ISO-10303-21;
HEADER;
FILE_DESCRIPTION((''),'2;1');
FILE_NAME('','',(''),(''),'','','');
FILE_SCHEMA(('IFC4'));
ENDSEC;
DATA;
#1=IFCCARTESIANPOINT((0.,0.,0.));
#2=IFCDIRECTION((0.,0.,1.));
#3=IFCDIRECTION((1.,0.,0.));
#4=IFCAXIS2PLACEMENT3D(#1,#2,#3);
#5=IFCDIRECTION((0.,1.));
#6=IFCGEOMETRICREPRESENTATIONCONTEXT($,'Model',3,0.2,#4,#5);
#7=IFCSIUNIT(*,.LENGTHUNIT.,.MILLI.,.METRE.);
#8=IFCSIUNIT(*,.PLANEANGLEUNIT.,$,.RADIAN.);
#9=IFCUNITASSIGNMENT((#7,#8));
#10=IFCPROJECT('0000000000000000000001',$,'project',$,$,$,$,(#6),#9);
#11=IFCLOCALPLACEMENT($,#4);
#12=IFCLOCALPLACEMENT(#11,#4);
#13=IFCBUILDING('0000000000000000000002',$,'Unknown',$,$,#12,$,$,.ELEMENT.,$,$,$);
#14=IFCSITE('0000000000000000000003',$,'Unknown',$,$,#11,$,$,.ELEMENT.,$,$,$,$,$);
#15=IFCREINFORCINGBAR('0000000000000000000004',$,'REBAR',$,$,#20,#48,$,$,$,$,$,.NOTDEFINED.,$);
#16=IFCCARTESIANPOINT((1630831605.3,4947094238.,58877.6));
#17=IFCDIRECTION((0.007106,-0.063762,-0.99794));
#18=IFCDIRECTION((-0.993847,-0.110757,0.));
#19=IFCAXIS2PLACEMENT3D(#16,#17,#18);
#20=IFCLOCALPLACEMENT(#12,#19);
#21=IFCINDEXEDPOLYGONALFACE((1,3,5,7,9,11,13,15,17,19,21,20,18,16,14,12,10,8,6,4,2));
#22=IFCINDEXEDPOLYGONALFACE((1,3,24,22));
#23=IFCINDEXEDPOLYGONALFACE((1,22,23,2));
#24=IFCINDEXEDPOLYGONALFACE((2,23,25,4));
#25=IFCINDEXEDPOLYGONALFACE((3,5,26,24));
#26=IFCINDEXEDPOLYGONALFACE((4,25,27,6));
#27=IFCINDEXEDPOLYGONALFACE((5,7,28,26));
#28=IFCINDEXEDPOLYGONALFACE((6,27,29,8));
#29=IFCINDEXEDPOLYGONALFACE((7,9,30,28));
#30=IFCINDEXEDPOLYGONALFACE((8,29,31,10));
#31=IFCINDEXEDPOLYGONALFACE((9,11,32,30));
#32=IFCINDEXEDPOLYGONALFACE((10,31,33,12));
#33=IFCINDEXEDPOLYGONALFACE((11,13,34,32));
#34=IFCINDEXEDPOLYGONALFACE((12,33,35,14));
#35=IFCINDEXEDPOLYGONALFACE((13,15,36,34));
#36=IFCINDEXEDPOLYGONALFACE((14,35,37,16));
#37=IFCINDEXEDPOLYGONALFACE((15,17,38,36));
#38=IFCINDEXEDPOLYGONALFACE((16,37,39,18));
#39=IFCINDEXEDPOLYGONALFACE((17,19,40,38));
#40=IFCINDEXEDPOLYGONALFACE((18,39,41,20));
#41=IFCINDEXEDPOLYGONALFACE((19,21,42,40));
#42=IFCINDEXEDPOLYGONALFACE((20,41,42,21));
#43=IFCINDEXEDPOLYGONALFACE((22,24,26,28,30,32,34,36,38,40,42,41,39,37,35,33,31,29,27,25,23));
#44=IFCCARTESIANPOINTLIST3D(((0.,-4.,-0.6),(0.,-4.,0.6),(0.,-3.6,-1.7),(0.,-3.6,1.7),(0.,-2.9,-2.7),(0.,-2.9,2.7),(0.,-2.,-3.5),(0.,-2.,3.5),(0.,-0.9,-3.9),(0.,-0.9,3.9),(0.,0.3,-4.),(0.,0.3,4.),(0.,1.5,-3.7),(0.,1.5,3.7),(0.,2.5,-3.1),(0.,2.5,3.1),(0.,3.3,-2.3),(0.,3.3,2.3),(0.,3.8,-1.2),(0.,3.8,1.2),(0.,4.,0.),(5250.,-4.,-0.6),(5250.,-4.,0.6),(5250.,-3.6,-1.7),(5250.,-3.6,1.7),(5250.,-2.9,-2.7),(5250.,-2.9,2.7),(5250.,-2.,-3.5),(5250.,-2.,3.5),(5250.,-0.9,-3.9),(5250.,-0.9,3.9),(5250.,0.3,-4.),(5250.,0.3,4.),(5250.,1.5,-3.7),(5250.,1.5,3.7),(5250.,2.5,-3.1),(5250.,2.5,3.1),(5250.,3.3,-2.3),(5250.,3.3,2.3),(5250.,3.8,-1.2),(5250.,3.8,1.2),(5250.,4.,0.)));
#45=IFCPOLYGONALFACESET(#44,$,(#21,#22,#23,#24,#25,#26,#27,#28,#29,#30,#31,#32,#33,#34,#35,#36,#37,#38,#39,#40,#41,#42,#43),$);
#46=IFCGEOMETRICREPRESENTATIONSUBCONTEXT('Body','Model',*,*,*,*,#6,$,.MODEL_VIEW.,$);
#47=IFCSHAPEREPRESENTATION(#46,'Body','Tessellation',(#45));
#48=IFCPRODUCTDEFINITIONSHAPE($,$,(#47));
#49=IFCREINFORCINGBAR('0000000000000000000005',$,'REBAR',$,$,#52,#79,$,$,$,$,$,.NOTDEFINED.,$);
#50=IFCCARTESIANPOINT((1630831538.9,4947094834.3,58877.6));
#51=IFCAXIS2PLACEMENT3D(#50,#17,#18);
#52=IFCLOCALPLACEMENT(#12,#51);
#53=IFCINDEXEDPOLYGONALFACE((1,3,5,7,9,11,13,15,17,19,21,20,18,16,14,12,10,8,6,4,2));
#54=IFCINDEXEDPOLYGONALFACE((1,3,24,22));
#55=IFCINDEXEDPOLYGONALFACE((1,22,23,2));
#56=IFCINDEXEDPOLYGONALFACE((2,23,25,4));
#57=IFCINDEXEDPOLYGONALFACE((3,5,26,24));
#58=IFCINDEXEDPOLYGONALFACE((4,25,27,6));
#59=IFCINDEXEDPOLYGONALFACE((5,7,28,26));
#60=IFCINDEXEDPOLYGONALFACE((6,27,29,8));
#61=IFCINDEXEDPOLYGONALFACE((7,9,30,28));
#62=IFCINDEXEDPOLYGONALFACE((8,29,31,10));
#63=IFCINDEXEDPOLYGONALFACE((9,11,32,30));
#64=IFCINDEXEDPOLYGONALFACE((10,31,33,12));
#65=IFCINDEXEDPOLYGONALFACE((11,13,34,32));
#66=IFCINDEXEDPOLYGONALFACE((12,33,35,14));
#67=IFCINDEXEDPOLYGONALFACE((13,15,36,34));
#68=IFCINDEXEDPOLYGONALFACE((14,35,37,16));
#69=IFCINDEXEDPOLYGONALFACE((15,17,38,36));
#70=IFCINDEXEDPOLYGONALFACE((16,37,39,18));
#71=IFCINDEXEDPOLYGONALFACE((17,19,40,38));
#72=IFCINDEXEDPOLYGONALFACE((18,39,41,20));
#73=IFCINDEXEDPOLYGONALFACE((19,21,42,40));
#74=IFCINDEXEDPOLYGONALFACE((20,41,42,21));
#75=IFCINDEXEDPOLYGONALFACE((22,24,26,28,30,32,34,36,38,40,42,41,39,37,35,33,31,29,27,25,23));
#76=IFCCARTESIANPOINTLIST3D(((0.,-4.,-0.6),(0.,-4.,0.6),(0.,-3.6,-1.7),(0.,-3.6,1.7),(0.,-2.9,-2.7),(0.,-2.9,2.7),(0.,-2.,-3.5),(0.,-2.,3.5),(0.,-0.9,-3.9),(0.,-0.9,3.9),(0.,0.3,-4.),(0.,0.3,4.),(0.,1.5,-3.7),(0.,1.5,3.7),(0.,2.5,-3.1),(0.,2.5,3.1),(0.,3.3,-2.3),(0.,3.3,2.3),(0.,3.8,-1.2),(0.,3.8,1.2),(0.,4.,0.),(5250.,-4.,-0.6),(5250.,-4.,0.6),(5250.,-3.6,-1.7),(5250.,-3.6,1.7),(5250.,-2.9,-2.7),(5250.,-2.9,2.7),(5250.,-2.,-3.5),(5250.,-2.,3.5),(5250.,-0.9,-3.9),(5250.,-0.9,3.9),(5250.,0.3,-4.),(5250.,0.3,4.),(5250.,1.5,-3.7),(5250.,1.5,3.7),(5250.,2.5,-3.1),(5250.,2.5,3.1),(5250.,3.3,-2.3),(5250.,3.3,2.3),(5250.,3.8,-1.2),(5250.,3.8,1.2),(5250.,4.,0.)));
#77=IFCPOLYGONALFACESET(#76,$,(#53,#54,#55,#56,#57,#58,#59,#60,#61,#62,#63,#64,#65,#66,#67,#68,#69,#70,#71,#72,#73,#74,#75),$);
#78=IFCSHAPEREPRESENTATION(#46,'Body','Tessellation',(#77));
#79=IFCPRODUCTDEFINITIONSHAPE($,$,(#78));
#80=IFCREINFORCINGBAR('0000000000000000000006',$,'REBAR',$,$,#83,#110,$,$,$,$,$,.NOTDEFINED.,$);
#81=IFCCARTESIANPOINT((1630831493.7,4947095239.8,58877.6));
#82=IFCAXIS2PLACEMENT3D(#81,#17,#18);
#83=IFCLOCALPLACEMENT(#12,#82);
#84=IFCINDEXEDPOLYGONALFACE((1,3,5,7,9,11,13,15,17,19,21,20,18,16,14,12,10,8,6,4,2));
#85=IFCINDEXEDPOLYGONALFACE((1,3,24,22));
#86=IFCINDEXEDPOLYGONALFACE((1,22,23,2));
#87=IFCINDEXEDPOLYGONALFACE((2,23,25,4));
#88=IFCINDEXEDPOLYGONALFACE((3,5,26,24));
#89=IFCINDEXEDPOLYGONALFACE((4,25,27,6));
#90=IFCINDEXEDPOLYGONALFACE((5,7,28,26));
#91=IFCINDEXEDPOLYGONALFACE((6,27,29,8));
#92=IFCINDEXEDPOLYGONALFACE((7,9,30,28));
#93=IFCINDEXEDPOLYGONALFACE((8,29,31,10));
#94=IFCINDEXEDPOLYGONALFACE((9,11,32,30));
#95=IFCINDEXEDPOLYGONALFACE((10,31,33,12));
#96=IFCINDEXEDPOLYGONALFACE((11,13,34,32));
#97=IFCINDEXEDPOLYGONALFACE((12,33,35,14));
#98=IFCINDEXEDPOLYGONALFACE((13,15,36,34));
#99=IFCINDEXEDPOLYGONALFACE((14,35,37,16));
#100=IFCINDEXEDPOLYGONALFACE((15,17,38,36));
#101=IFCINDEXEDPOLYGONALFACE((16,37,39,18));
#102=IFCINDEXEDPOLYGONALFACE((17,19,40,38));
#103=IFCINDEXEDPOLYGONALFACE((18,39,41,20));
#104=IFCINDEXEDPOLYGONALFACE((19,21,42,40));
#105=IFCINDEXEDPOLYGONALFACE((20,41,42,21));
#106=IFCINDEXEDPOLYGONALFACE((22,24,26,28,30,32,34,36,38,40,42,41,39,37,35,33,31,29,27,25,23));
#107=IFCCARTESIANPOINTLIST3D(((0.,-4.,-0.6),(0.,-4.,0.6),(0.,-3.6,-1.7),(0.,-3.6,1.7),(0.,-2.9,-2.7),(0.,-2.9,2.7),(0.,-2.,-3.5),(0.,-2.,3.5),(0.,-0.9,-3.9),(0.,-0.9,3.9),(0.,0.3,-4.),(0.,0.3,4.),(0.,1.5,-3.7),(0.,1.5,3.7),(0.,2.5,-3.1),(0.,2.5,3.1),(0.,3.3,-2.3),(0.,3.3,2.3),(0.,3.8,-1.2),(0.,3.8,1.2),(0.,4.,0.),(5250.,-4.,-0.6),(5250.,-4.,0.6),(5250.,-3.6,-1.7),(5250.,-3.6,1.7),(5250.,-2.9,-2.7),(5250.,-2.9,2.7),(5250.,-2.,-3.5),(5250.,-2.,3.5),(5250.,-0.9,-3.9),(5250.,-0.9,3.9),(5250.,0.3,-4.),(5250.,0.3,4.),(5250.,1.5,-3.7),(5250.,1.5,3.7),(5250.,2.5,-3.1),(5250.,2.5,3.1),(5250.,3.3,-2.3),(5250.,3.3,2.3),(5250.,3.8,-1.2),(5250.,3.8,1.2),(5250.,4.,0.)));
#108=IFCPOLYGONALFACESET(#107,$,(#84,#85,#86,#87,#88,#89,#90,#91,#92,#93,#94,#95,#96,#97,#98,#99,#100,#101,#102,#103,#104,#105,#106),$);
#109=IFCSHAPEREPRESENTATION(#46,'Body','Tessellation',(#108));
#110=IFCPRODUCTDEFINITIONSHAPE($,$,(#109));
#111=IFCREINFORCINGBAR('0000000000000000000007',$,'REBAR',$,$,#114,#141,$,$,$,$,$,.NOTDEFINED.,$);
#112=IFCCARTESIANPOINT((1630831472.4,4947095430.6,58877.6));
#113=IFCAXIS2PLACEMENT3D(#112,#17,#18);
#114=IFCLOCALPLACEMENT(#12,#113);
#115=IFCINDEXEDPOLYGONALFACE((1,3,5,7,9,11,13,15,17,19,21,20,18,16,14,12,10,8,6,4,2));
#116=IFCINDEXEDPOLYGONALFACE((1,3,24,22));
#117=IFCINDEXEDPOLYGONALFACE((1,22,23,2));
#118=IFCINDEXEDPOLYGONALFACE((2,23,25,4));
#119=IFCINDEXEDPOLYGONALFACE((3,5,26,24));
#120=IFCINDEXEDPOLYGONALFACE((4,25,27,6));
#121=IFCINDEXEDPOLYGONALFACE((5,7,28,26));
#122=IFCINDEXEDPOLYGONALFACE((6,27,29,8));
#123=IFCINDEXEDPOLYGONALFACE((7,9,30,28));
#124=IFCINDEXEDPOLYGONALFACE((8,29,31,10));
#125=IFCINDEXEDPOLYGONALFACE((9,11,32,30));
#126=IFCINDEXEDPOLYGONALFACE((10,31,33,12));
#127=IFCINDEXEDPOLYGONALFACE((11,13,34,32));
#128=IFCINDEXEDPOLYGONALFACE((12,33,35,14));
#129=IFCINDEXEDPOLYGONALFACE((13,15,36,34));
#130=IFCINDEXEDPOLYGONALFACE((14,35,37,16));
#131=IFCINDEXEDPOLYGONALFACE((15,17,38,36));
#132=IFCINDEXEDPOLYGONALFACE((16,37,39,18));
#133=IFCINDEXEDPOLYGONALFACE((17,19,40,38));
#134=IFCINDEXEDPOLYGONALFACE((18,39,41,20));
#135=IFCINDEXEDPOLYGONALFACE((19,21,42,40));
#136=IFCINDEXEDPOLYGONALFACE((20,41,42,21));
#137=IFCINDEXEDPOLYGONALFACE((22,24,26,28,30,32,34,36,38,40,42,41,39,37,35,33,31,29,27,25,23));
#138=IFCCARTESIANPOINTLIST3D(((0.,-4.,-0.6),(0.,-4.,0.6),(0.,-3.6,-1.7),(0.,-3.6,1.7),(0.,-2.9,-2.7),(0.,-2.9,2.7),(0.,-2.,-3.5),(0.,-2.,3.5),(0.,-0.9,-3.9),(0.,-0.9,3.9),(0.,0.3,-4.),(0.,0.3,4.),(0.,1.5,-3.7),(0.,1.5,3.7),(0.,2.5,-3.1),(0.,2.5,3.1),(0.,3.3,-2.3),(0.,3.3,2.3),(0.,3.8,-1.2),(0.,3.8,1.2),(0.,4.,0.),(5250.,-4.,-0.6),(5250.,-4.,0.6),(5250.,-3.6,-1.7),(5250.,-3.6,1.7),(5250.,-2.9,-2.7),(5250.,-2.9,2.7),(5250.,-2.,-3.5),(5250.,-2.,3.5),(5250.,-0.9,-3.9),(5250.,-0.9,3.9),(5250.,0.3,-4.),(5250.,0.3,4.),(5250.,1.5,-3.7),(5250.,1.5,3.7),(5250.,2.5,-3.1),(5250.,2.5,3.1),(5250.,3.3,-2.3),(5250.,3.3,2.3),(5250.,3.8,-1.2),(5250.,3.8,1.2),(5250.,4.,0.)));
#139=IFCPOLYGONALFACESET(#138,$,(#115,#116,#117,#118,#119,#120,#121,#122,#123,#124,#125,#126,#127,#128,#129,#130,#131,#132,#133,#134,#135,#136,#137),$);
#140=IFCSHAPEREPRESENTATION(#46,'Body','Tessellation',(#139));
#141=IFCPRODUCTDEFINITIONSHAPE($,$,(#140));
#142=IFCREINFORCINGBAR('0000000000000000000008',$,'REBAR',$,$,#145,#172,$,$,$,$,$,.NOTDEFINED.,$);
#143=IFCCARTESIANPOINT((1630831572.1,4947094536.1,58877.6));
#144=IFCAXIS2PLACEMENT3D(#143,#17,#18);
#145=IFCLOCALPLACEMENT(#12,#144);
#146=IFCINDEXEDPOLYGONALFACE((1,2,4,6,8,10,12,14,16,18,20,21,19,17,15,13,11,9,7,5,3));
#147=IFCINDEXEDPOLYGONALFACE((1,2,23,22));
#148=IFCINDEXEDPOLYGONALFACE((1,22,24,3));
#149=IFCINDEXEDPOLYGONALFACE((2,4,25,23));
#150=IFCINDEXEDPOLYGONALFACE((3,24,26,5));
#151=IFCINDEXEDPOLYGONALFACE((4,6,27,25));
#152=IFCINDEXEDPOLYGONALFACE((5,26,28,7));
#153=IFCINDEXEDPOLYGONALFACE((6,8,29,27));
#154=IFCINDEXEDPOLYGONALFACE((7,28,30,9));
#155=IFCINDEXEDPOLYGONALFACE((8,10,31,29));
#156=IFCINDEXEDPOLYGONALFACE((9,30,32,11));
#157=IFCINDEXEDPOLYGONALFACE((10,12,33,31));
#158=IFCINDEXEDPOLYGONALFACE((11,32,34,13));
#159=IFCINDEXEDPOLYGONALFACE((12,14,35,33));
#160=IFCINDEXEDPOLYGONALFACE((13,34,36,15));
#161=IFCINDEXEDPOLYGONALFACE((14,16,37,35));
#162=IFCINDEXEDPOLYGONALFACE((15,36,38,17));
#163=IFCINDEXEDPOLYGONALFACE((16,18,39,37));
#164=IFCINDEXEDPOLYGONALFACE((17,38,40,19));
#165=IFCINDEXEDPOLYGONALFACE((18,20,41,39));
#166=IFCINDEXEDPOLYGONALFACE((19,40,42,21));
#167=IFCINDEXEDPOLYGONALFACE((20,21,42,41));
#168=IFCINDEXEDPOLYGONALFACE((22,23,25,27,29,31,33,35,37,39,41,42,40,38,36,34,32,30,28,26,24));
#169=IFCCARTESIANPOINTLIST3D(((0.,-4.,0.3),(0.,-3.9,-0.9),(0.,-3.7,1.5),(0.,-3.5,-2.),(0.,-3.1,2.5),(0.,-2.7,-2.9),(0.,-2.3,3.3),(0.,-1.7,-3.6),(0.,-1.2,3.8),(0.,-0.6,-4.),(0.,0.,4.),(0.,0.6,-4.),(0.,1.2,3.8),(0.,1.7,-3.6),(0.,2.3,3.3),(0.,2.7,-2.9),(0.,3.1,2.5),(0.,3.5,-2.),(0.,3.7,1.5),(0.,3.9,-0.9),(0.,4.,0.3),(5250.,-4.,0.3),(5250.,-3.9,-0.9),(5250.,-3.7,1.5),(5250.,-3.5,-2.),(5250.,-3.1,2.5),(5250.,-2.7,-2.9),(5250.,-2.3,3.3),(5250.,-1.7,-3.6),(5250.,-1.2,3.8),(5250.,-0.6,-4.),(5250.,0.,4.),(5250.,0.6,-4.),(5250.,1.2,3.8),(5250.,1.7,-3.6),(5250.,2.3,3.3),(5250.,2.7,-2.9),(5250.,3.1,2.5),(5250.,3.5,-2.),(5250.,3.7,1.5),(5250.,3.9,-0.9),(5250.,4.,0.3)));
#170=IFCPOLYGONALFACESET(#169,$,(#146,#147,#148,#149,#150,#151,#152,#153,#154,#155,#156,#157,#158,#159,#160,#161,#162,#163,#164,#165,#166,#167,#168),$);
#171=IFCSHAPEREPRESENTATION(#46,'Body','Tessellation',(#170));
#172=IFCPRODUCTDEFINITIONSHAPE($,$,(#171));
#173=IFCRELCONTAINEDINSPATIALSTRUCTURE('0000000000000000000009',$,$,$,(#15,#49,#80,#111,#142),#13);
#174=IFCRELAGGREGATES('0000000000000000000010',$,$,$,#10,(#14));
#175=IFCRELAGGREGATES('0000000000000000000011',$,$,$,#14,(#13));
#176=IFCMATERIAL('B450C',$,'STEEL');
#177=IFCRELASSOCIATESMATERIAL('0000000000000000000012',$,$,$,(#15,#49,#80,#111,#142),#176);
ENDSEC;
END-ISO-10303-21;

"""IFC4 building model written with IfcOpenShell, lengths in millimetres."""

from ifc_helpers import new_model, entity, si_unit, direction, frame, origin_with_axes, place, context, subcontext, project, spatial, material, element, save


model = new_model("IFC4")

# Units and contexts
model_context = context("Model", 3, precision=0.2, world=origin_with_axes(), true_north=direction((0.0, 1.0)))
body_context = subcontext(model_context, "Body", "Model", "MODEL_VIEW")
ifc_project = project(units=[si_unit("LENGTHUNIT", "METRE", prefix="MILLI"), si_unit("PLANEANGLEUNIT", "RADIAN")], contexts=[model_context])

# Site, building
site_placement = place(None, origin_with_axes())
site = spatial("IfcSite", under=ifc_project, at=site_placement, Name="Unknown", CompositionType="ELEMENT")
building_placement = place(site_placement, origin_with_axes())
building = spatial("IfcBuilding", under=site, at=building_placement, Name="Unknown", CompositionType="ELEMENT")

# Reinforcing bars
ifc_material = material(Name="B450C", Category="STEEL")
reinforcing_bar_1_placement = place(building_placement, frame((1630831605.3, 4947094238.0, 58877.6), z_axis=(0.007106, -0.063762, -0.99794), x_axis=(-0.993847, -0.110757, 0.0)))
element("IfcReinforcingBar", 1, at=reinforcing_bar_1_placement, inside=building, material=ifc_material, Name="REBAR", PredefinedType="NOTDEFINED", context=body_context, shape_type="AdvancedSweptSolid", body=[
    entity("IfcSweptDiskSolid", entity("IfcIndexedPolyCurve", entity("IfcCartesianPointList3D", [[0.0, 0.0, 0.0], [5250.0, 0.0, 0.0]]), [entity("IfcLineIndex", [1, 2])]), 4.0),
])
reinforcing_bar_2_placement = place(building_placement, frame((1630831538.9, 4947094834.3, 58877.6), z_axis=(0.007106, -0.063762, -0.99794), x_axis=(-0.993847, -0.110757, 0.0)))
element("IfcReinforcingBar", 2, at=reinforcing_bar_2_placement, inside=building, material=ifc_material, Name="REBAR", PredefinedType="NOTDEFINED", context=body_context, shape_type="AdvancedSweptSolid", body=[
    entity("IfcSweptDiskSolid", entity("IfcIndexedPolyCurve", entity("IfcCartesianPointList3D", [[0.0, 0.0, 0.0], [5250.0, 0.0, 0.0]]), [entity("IfcLineIndex", [1, 2])]), 4.0),
])
reinforcing_bar_3_placement = place(building_placement, frame((1630831493.7, 4947095239.8, 58877.6), z_axis=(0.007106, -0.063762, -0.99794), x_axis=(-0.993847, -0.110757, 0.0)))
element("IfcReinforcingBar", 3, at=reinforcing_bar_3_placement, inside=building, material=ifc_material, Name="REBAR", PredefinedType="NOTDEFINED", context=body_context, shape_type="AdvancedSweptSolid", body=[
    entity("IfcSweptDiskSolid", entity("IfcIndexedPolyCurve", entity("IfcCartesianPointList3D", [[0.0, 0.0, 0.0], [5250.0, 0.0, 0.0]]), [entity("IfcLineIndex", [1, 2])]), 4.0),
])
reinforcing_bar_4_placement = place(building_placement, frame((1630831472.4, 4947095430.6, 58877.6), z_axis=(0.007106, -0.063762, -0.99794), x_axis=(-0.993847, -0.110757, 0.0)))
element("IfcReinforcingBar", 4, at=reinforcing_bar_4_placement, inside=building, material=ifc_material, Name="REBAR", PredefinedType="NOTDEFINED", context=body_context, shape_type="AdvancedSweptSolid", body=[
    entity("IfcSweptDiskSolid", entity("IfcIndexedPolyCurve", entity("IfcCartesianPointList3D", [[0.0, 0.0, 0.0], [5250.0, 0.0, 0.0]]), [entity("IfcLineIndex", [1, 2])]), 4.0),
])
reinforcing_bar_5_placement = place(building_placement, frame((1630831572.1, 4947094536.1, 58877.6), z_axis=(0.007106, -0.063762, -0.99794), x_axis=(-0.993847, -0.110757, 0.0)))
element("IfcReinforcingBar", 5, at=reinforcing_bar_5_placement, inside=building, material=ifc_material, Name="REBAR", PredefinedType="NOTDEFINED", context=body_context, shape_type="AdvancedSweptSolid", body=[
    entity("IfcSweptDiskSolid", entity("IfcIndexedPolyCurve", entity("IfcCartesianPointList3D", [[0.0, 0.0, 0.0], [5250.0, 0.0, 0.0]]), [entity("IfcLineIndex", [1, 2])]), 4.0),
])

save(model, "model.ifc")
